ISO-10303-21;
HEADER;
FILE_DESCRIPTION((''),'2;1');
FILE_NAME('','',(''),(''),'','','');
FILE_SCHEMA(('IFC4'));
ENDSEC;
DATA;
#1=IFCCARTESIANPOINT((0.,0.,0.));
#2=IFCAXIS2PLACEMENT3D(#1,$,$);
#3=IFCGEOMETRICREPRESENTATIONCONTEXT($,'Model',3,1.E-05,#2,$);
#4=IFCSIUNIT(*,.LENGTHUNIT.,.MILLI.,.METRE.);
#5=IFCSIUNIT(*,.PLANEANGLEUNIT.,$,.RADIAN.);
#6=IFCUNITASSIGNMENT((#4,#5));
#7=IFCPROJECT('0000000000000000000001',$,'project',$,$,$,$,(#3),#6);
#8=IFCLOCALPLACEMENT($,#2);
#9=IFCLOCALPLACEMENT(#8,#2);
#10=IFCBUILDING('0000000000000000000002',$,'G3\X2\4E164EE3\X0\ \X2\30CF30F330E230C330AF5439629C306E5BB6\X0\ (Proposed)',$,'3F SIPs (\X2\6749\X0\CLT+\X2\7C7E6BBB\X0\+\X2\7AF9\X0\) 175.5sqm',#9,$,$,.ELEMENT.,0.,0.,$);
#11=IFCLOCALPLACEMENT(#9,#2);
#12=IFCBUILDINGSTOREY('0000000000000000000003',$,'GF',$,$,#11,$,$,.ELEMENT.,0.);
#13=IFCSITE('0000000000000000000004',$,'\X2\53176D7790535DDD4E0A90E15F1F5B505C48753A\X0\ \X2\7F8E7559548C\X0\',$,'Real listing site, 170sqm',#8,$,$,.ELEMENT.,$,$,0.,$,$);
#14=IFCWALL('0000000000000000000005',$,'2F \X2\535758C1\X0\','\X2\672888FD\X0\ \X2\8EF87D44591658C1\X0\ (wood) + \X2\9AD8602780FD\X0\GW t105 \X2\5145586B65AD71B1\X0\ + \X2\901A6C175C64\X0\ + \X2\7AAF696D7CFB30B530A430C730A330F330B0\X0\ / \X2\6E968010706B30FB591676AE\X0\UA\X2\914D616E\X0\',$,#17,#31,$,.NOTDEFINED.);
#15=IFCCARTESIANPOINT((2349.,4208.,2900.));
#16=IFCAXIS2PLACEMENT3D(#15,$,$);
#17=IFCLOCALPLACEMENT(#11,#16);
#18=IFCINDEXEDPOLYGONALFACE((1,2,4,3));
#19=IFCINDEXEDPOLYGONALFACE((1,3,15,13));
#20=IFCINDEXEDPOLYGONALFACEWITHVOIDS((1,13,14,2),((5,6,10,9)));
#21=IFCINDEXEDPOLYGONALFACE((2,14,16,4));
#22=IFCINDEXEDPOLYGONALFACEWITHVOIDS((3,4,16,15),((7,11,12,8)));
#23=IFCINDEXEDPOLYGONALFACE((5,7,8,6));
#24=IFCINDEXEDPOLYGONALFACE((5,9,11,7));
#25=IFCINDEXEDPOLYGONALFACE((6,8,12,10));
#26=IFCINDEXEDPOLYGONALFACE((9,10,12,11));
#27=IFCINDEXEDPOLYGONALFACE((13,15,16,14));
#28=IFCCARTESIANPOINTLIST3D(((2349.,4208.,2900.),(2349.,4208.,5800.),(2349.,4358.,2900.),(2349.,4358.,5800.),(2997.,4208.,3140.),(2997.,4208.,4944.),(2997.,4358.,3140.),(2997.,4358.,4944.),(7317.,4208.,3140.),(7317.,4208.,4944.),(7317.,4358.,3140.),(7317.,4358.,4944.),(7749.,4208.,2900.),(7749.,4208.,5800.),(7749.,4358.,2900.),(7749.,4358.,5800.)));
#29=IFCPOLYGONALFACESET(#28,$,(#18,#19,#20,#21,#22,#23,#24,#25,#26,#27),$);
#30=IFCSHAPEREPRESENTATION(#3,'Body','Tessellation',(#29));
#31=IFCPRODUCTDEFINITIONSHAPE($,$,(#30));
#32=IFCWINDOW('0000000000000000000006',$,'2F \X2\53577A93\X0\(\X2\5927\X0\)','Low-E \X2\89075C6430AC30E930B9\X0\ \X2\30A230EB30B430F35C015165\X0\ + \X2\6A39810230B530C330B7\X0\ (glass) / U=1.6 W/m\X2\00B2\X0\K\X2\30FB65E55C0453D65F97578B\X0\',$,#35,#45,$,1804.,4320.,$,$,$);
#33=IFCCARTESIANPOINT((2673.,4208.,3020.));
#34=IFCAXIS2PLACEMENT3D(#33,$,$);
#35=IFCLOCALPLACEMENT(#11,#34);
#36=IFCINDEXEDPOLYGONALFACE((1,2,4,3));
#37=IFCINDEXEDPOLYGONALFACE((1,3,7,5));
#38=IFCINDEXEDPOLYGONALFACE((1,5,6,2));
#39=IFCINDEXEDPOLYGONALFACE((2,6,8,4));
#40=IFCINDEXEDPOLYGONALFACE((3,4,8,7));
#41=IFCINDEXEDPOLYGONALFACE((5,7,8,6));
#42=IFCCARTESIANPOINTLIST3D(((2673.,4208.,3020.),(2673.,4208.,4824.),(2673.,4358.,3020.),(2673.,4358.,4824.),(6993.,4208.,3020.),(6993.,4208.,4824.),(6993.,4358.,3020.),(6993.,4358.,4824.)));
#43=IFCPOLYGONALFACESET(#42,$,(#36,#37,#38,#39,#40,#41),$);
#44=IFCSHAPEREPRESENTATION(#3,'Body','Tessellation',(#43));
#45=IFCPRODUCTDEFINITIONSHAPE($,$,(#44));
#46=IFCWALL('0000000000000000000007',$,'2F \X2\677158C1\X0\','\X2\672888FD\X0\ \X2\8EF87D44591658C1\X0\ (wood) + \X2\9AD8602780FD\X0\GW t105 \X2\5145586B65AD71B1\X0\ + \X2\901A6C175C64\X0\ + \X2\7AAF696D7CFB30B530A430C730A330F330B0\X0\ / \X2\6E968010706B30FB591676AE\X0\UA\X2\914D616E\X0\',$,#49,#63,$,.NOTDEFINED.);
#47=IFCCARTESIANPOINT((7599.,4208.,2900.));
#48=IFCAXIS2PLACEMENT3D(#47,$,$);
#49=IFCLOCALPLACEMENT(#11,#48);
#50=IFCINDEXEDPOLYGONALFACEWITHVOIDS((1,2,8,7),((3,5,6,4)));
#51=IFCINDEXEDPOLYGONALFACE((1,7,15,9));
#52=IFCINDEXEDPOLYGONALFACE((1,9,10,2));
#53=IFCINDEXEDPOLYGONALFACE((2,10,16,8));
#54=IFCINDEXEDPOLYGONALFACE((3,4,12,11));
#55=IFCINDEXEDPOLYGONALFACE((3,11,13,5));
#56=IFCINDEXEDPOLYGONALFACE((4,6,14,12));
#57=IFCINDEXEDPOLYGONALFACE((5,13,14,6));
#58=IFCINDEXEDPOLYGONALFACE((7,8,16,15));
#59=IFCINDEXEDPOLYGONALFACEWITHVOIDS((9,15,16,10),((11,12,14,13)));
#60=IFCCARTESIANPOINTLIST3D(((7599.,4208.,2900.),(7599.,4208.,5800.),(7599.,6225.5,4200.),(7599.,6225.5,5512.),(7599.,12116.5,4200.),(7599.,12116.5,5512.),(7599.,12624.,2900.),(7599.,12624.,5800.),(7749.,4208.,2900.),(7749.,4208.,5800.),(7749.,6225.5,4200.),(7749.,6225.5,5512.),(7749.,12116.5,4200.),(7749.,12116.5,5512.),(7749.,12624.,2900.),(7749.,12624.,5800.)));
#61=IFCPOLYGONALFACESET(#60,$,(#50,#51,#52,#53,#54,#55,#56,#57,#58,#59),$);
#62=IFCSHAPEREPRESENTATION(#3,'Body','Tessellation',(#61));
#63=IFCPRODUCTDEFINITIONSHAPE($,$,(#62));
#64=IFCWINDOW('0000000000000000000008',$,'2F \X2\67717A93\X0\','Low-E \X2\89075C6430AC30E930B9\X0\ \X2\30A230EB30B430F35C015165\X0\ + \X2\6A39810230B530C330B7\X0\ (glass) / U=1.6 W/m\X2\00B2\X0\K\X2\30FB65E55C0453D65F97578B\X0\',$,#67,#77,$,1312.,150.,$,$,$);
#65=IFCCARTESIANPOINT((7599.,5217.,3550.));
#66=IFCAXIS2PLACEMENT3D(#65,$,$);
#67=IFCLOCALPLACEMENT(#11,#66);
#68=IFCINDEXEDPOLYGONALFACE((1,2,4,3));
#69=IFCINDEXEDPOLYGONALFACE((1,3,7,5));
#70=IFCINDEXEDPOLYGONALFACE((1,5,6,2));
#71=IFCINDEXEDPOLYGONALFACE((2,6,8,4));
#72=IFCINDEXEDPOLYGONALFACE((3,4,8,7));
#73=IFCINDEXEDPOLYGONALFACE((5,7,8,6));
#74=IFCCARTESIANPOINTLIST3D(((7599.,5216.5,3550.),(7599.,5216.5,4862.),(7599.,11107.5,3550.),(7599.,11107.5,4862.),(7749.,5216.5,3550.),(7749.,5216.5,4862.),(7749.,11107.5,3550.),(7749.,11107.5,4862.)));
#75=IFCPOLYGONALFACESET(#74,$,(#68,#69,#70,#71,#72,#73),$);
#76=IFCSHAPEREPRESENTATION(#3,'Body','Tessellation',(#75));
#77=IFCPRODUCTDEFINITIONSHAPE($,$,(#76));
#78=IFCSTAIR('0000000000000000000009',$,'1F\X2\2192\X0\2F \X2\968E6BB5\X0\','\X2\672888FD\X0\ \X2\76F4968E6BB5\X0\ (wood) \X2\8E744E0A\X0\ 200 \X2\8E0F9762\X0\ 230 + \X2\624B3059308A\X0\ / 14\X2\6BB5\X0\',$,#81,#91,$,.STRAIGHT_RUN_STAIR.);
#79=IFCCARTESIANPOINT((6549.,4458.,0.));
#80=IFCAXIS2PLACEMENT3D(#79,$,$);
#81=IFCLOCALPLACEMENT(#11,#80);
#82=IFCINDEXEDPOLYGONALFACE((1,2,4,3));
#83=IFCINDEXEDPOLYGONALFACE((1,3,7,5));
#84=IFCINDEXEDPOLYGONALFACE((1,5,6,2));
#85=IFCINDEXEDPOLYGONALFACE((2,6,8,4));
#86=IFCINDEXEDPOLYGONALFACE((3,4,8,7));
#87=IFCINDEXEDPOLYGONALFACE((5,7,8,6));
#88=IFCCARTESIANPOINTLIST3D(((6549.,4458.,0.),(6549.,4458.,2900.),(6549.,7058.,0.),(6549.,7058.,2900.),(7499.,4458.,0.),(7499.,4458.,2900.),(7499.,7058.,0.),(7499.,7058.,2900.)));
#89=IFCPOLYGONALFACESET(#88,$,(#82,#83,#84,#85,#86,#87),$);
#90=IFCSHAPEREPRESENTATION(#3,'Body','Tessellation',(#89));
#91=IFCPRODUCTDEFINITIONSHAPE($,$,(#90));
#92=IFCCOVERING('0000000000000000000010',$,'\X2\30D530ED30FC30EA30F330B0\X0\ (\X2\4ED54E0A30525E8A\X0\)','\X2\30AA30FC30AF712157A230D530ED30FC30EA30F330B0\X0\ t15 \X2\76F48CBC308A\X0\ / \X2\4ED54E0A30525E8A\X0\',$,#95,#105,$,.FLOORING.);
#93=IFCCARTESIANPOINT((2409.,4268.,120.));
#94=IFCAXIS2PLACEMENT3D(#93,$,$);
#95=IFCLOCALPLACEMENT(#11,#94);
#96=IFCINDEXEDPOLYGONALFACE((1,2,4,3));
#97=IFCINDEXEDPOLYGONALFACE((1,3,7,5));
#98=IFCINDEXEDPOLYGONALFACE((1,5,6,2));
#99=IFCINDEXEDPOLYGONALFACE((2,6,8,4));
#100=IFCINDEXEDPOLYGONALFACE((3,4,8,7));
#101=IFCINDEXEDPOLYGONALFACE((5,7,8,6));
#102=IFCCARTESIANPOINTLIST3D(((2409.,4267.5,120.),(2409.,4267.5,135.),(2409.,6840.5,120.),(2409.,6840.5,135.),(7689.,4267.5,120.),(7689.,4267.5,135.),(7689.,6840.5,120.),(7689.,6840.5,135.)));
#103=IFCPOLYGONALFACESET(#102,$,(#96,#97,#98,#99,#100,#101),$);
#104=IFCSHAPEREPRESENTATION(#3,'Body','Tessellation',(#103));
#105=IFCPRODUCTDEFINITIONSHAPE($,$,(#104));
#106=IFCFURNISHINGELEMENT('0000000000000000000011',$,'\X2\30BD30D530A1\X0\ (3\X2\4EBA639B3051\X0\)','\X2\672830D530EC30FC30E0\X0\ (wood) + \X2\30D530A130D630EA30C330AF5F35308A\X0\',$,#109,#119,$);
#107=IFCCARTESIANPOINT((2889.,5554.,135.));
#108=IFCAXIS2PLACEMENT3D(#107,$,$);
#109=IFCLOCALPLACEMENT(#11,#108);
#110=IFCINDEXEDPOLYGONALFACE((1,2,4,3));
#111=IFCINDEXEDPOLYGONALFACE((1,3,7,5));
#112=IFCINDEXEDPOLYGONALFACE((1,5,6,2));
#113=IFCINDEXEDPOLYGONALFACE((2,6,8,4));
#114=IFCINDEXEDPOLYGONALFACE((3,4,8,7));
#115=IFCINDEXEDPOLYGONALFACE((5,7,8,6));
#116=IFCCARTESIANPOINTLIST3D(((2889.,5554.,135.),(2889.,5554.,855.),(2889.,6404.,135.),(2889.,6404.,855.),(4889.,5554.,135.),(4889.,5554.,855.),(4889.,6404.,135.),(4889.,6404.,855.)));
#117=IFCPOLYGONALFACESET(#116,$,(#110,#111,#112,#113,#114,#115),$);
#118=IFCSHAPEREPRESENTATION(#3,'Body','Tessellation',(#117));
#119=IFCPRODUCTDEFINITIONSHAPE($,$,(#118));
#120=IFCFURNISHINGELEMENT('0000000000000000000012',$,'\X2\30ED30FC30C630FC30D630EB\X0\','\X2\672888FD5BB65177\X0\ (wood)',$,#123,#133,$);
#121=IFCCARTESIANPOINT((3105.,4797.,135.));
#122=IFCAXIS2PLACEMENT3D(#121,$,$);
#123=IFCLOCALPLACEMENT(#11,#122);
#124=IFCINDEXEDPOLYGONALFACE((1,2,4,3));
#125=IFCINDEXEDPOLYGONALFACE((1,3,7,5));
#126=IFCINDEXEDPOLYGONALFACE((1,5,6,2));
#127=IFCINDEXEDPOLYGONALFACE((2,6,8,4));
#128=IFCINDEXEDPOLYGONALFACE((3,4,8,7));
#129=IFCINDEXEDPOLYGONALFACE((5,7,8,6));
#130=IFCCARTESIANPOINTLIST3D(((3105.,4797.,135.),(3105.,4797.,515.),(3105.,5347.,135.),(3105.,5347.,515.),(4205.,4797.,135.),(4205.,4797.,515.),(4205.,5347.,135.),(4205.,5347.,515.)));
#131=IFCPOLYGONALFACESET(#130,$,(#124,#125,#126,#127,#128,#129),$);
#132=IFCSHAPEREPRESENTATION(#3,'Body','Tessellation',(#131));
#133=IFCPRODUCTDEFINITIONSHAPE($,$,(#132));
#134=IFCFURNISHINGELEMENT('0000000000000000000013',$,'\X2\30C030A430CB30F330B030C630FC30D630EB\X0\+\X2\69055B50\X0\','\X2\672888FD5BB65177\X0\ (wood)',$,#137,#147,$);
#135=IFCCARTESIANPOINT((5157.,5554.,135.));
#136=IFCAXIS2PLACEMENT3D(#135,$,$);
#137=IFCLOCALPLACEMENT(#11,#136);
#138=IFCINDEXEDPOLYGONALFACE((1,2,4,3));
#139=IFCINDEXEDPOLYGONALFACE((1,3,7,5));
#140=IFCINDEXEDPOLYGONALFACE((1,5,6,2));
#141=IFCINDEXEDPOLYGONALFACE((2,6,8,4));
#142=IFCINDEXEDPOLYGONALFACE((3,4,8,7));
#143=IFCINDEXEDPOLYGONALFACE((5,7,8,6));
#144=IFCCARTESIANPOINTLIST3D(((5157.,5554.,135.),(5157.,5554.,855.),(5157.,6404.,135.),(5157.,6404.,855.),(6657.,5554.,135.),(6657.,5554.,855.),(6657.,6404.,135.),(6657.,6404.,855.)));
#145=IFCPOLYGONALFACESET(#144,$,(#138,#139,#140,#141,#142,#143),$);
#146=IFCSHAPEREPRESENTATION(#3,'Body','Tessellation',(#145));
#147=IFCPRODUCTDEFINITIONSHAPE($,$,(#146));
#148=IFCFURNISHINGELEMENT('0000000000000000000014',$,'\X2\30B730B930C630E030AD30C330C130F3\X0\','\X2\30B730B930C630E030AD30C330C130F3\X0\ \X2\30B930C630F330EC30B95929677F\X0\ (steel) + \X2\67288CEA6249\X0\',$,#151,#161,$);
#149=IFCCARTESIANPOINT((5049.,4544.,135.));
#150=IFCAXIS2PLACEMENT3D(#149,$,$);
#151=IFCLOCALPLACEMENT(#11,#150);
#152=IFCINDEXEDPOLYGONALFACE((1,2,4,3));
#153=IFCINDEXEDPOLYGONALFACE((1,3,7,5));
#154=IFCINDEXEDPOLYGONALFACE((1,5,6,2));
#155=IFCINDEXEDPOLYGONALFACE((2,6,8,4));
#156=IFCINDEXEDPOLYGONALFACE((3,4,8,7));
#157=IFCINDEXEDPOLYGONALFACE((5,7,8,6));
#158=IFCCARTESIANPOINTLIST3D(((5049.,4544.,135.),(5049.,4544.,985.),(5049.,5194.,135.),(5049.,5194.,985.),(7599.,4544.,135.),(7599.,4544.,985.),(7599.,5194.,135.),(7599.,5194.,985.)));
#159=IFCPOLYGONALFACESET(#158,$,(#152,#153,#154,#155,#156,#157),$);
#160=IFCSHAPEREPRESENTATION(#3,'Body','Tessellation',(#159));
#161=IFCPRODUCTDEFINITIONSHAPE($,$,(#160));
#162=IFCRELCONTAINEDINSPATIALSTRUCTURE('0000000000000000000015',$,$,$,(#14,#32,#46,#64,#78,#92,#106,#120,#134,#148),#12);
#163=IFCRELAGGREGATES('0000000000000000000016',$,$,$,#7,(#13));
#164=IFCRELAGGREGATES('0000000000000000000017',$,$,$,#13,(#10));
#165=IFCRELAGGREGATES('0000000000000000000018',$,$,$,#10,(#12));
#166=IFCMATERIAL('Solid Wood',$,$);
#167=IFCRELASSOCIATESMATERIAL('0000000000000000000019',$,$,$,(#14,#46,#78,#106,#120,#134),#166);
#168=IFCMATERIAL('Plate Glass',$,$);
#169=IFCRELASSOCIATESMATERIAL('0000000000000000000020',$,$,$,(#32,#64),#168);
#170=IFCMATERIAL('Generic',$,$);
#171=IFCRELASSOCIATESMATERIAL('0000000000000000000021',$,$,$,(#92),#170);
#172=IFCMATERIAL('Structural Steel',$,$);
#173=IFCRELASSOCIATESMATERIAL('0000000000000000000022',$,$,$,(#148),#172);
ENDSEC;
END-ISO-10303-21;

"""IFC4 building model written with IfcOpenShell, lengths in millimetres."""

from ifc_helpers import new_model, si_unit, frame, frame_2d, origin, place, context, project, spatial, rectangle, extrude, material, element, fill, save


model = new_model("IFC4")

# Units and contexts
model_context = context("Model", 3, precision=1e-05, world=origin())
ifc_project = project(units=[si_unit("LENGTHUNIT", "METRE", prefix="MILLI"), si_unit("PLANEANGLEUNIT", "RADIAN")], contexts=[model_context])

# Site, building, storey
site_placement = place(None, origin())
site = spatial("IfcSite", under=ifc_project, at=site_placement, Name="北海道川上郡弟子屈町 美留和", ObjectType="Real listing site, 170sqm", CompositionType="ELEMENT", RefElevation=0.0)
building_placement = place(site_placement, origin())
building = spatial("IfcBuilding", under=site, at=building_placement, Name="G3世代 ハンモック吹抜の家 (Proposed)", ObjectType="3F SIPs (杉CLT+籾殻+竹) 175.5sqm", CompositionType="ELEMENT", ElevationOfRefHeight=0.0, ElevationOfTerrain=0.0)
storey_placement = place(building_placement, origin())
storey = spatial("IfcBuildingStorey", under=building, at=storey_placement, Name="GF", CompositionType="ELEMENT", Elevation=0.0)

# Shared definitions
ifc_material_1 = material(Name="Solid Wood")
ifc_material_2 = material(Name="Generic")

# Shared definitions
ifc_material_3 = material(Name="Plate Glass")

# Walls, openings, windows
wall_1_placement = place(storey_placement, frame((2349.0, 4208.0, 2900.0)))
wall_1 = element("IfcWall", 1, at=wall_1_placement, inside=storey, material=ifc_material_1, Name="2F 南壁", Description="木製 軸組外壁 (wood) + 高性能GW t105 充填断熱 + 通気層 + 窯業系サイディング / 準耐火・外皮UA配慮", PredefinedType="NOTDEFINED", context=model_context, shape_type="SweptSolid", body=[
    extrude(rectangle(XDim=5400.0, YDim=150.0, at=frame_2d((2700.0, 75.0))), frame((2349.0, 4208.0, 2900.0)), (0.0, 0.0, 1.0), 2900.0),
])
opening_1_placement = place(storey_placement, frame((2673.0, 4208.0, 3020.0)))
opening_1 = element("IfcOpeningElement", 2, at=opening_1_placement, cuts=wall_1, PredefinedType="NOTDEFINED", context=model_context, shape_type="SweptSolid", body=[
    extrude(rectangle(XDim=4320.0, YDim=150.0, at=frame_2d((2160.0, 75.0))), frame((2673.0, 4208.0, 3020.0)), (0.0, 0.0, 1.0), 1804.0),
])
window_1_placement = place(storey_placement, frame((2673.0, 4208.0, 3020.0)))
window_1 = element("IfcWindow", 3, at=window_1_placement, inside=storey, material=ifc_material_3, Name="2F 南窓(大)", Description="Low-E 複層ガラス アルゴン封入 + 樹脂サッシ (glass) / U=1.6 W/m²K・日射取得型", OverallHeight=1804.0, OverallWidth=4320.0, context=model_context, shape_type="SweptSolid", body=[
    extrude(rectangle(XDim=4320.0, YDim=150.0, at=frame_2d((2160.0, 75.0))), frame((2673.0, 4208.0, 3020.0)), (0.0, 0.0, 1.0), 1804.0),
])
fill(opening_1, window_1)
wall_2_placement = place(storey_placement, frame((7599.0, 4208.0, 2900.0)))
wall_2 = element("IfcWall", 4, at=wall_2_placement, inside=storey, material=ifc_material_1, Name="2F 東壁", Description="木製 軸組外壁 (wood) + 高性能GW t105 充填断熱 + 通気層 + 窯業系サイディング / 準耐火・外皮UA配慮", PredefinedType="NOTDEFINED", context=model_context, shape_type="SweptSolid", body=[
    extrude(rectangle(XDim=150.0, YDim=8416.0, at=frame_2d((75.0, 4208.0))), frame((7599.0, 4208.0, 2900.0)), (0.0, 0.0, 1.0), 2900.0),
])
opening_2_placement = place(storey_placement, frame((7599.0, 5217.0, 3550.0)))
opening_2 = element("IfcOpeningElement", 5, at=opening_2_placement, cuts=wall_2, PredefinedType="NOTDEFINED", context=model_context, shape_type="SweptSolid", body=[
    extrude(rectangle(XDim=150.0, YDim=5891.0, at=frame_2d((75.0, 2945.0))), frame((7599.0, 5217.0, 3550.0)), (0.0, 0.0, 1.0), 1312.0),
])
window_2_placement = place(storey_placement, frame((7599.0, 5217.0, 3550.0)))
window_2 = element("IfcWindow", 6, at=window_2_placement, inside=storey, material=ifc_material_3, Name="2F 東窓", Description="Low-E 複層ガラス アルゴン封入 + 樹脂サッシ (glass) / U=1.6 W/m²K・日射取得型", OverallHeight=1312.0, OverallWidth=150.0, context=model_context, shape_type="SweptSolid", body=[
    extrude(rectangle(XDim=150.0, YDim=5891.0, at=frame_2d((75.0, 2945.0))), frame((7599.0, 5217.0, 3550.0)), (0.0, 0.0, 1.0), 1312.0),
])
fill(opening_2, window_2)

# Stair
stair_placement = place(storey_placement, frame((6549.0, 4458.0, 0.0)))
element("IfcStair", 7, at=stair_placement, inside=storey, material=ifc_material_1, Name="1F→2F 階段", Description="木製 直階段 (wood) 蹴上 200 踏面 230 + 手すり / 14段", PredefinedType="STRAIGHT_RUN_STAIR", context=model_context, shape_type="SweptSolid", body=[
    extrude(rectangle(XDim=950.0, YDim=2600.0, at=frame_2d((475.0, 1300.0))), frame((6549.0, 4458.0, 0.0)), (0.0, 0.0, 1.0), 2900.0),
])

# Covering
covering_placement = place(storey_placement, frame((2409.0, 4268.0, 120.0)))
element("IfcCovering", 8, at=covering_placement, inside=storey, material=ifc_material_2, Name="フローリング (仕上げ床)", Description="オーク無垢フローリング t15 直貼り / 仕上げ床", PredefinedType="FLOORING", context=model_context, shape_type="SweptSolid", body=[
    extrude(rectangle(XDim=5280.0, YDim=2573.0, at=frame_2d((2640.0, 1286.0))), frame((2409.0, 4268.0, 120.0)), (0.0, 0.0, 1.0), 15.0),
])

# Furnishing elements
furnishing_1_placement = place(storey_placement, frame((2889.0, 5554.0, 135.0)))
element("IfcFurnishingElement", 9, at=furnishing_1_placement, inside=storey, material=ifc_material_1, Name="ソファ (3人掛け)", Description="木フレーム (wood) + ファブリック張り", context=model_context, shape_type="SweptSolid", body=[
    extrude(rectangle(XDim=2000.0, YDim=850.0, at=frame_2d((1000.0, 425.0))), frame((2889.0, 5554.0, 135.0)), (0.0, 0.0, 1.0), 720.0),
])
furnishing_2_placement = place(storey_placement, frame((3105.0, 4797.0, 135.0)))
element("IfcFurnishingElement", 10, at=furnishing_2_placement, inside=storey, material=ifc_material_1, Name="ローテーブル", Description="木製家具 (wood)", context=model_context, shape_type="SweptSolid", body=[
    extrude(rectangle(XDim=1100.0, YDim=550.0, at=frame_2d((550.0, 275.0))), frame((3105.0, 4797.0, 135.0)), (0.0, 0.0, 1.0), 380.0),
])
furnishing_3_placement = place(storey_placement, frame((5157.0, 5554.0, 135.0)))
element("IfcFurnishingElement", 11, at=furnishing_3_placement, inside=storey, material=ifc_material_1, Name="ダイニングテーブル+椅子", Description="木製家具 (wood)", context=model_context, shape_type="SweptSolid", body=[
    extrude(rectangle(XDim=1500.0, YDim=850.0, at=frame_2d((750.0, 425.0))), frame((5157.0, 5554.0, 135.0)), (0.0, 0.0, 1.0), 720.0),
])
ifc_material_4 = material(Name="Structural Steel")
furnishing_4_placement = place(storey_placement, frame((5049.0, 4544.0, 135.0)))
element("IfcFurnishingElement", 12, at=furnishing_4_placement, inside=storey, material=ifc_material_4, Name="システムキッチン", Description="システムキッチン ステンレス天板 (steel) + 木質扉", context=model_context, shape_type="SweptSolid", body=[
    extrude(rectangle(XDim=2550.0, YDim=650.0, at=frame_2d((1275.0, 325.0))), frame((5049.0, 4544.0, 135.0)), (0.0, 0.0, 1.0), 850.0),
])

save(model, "model.ifc")
